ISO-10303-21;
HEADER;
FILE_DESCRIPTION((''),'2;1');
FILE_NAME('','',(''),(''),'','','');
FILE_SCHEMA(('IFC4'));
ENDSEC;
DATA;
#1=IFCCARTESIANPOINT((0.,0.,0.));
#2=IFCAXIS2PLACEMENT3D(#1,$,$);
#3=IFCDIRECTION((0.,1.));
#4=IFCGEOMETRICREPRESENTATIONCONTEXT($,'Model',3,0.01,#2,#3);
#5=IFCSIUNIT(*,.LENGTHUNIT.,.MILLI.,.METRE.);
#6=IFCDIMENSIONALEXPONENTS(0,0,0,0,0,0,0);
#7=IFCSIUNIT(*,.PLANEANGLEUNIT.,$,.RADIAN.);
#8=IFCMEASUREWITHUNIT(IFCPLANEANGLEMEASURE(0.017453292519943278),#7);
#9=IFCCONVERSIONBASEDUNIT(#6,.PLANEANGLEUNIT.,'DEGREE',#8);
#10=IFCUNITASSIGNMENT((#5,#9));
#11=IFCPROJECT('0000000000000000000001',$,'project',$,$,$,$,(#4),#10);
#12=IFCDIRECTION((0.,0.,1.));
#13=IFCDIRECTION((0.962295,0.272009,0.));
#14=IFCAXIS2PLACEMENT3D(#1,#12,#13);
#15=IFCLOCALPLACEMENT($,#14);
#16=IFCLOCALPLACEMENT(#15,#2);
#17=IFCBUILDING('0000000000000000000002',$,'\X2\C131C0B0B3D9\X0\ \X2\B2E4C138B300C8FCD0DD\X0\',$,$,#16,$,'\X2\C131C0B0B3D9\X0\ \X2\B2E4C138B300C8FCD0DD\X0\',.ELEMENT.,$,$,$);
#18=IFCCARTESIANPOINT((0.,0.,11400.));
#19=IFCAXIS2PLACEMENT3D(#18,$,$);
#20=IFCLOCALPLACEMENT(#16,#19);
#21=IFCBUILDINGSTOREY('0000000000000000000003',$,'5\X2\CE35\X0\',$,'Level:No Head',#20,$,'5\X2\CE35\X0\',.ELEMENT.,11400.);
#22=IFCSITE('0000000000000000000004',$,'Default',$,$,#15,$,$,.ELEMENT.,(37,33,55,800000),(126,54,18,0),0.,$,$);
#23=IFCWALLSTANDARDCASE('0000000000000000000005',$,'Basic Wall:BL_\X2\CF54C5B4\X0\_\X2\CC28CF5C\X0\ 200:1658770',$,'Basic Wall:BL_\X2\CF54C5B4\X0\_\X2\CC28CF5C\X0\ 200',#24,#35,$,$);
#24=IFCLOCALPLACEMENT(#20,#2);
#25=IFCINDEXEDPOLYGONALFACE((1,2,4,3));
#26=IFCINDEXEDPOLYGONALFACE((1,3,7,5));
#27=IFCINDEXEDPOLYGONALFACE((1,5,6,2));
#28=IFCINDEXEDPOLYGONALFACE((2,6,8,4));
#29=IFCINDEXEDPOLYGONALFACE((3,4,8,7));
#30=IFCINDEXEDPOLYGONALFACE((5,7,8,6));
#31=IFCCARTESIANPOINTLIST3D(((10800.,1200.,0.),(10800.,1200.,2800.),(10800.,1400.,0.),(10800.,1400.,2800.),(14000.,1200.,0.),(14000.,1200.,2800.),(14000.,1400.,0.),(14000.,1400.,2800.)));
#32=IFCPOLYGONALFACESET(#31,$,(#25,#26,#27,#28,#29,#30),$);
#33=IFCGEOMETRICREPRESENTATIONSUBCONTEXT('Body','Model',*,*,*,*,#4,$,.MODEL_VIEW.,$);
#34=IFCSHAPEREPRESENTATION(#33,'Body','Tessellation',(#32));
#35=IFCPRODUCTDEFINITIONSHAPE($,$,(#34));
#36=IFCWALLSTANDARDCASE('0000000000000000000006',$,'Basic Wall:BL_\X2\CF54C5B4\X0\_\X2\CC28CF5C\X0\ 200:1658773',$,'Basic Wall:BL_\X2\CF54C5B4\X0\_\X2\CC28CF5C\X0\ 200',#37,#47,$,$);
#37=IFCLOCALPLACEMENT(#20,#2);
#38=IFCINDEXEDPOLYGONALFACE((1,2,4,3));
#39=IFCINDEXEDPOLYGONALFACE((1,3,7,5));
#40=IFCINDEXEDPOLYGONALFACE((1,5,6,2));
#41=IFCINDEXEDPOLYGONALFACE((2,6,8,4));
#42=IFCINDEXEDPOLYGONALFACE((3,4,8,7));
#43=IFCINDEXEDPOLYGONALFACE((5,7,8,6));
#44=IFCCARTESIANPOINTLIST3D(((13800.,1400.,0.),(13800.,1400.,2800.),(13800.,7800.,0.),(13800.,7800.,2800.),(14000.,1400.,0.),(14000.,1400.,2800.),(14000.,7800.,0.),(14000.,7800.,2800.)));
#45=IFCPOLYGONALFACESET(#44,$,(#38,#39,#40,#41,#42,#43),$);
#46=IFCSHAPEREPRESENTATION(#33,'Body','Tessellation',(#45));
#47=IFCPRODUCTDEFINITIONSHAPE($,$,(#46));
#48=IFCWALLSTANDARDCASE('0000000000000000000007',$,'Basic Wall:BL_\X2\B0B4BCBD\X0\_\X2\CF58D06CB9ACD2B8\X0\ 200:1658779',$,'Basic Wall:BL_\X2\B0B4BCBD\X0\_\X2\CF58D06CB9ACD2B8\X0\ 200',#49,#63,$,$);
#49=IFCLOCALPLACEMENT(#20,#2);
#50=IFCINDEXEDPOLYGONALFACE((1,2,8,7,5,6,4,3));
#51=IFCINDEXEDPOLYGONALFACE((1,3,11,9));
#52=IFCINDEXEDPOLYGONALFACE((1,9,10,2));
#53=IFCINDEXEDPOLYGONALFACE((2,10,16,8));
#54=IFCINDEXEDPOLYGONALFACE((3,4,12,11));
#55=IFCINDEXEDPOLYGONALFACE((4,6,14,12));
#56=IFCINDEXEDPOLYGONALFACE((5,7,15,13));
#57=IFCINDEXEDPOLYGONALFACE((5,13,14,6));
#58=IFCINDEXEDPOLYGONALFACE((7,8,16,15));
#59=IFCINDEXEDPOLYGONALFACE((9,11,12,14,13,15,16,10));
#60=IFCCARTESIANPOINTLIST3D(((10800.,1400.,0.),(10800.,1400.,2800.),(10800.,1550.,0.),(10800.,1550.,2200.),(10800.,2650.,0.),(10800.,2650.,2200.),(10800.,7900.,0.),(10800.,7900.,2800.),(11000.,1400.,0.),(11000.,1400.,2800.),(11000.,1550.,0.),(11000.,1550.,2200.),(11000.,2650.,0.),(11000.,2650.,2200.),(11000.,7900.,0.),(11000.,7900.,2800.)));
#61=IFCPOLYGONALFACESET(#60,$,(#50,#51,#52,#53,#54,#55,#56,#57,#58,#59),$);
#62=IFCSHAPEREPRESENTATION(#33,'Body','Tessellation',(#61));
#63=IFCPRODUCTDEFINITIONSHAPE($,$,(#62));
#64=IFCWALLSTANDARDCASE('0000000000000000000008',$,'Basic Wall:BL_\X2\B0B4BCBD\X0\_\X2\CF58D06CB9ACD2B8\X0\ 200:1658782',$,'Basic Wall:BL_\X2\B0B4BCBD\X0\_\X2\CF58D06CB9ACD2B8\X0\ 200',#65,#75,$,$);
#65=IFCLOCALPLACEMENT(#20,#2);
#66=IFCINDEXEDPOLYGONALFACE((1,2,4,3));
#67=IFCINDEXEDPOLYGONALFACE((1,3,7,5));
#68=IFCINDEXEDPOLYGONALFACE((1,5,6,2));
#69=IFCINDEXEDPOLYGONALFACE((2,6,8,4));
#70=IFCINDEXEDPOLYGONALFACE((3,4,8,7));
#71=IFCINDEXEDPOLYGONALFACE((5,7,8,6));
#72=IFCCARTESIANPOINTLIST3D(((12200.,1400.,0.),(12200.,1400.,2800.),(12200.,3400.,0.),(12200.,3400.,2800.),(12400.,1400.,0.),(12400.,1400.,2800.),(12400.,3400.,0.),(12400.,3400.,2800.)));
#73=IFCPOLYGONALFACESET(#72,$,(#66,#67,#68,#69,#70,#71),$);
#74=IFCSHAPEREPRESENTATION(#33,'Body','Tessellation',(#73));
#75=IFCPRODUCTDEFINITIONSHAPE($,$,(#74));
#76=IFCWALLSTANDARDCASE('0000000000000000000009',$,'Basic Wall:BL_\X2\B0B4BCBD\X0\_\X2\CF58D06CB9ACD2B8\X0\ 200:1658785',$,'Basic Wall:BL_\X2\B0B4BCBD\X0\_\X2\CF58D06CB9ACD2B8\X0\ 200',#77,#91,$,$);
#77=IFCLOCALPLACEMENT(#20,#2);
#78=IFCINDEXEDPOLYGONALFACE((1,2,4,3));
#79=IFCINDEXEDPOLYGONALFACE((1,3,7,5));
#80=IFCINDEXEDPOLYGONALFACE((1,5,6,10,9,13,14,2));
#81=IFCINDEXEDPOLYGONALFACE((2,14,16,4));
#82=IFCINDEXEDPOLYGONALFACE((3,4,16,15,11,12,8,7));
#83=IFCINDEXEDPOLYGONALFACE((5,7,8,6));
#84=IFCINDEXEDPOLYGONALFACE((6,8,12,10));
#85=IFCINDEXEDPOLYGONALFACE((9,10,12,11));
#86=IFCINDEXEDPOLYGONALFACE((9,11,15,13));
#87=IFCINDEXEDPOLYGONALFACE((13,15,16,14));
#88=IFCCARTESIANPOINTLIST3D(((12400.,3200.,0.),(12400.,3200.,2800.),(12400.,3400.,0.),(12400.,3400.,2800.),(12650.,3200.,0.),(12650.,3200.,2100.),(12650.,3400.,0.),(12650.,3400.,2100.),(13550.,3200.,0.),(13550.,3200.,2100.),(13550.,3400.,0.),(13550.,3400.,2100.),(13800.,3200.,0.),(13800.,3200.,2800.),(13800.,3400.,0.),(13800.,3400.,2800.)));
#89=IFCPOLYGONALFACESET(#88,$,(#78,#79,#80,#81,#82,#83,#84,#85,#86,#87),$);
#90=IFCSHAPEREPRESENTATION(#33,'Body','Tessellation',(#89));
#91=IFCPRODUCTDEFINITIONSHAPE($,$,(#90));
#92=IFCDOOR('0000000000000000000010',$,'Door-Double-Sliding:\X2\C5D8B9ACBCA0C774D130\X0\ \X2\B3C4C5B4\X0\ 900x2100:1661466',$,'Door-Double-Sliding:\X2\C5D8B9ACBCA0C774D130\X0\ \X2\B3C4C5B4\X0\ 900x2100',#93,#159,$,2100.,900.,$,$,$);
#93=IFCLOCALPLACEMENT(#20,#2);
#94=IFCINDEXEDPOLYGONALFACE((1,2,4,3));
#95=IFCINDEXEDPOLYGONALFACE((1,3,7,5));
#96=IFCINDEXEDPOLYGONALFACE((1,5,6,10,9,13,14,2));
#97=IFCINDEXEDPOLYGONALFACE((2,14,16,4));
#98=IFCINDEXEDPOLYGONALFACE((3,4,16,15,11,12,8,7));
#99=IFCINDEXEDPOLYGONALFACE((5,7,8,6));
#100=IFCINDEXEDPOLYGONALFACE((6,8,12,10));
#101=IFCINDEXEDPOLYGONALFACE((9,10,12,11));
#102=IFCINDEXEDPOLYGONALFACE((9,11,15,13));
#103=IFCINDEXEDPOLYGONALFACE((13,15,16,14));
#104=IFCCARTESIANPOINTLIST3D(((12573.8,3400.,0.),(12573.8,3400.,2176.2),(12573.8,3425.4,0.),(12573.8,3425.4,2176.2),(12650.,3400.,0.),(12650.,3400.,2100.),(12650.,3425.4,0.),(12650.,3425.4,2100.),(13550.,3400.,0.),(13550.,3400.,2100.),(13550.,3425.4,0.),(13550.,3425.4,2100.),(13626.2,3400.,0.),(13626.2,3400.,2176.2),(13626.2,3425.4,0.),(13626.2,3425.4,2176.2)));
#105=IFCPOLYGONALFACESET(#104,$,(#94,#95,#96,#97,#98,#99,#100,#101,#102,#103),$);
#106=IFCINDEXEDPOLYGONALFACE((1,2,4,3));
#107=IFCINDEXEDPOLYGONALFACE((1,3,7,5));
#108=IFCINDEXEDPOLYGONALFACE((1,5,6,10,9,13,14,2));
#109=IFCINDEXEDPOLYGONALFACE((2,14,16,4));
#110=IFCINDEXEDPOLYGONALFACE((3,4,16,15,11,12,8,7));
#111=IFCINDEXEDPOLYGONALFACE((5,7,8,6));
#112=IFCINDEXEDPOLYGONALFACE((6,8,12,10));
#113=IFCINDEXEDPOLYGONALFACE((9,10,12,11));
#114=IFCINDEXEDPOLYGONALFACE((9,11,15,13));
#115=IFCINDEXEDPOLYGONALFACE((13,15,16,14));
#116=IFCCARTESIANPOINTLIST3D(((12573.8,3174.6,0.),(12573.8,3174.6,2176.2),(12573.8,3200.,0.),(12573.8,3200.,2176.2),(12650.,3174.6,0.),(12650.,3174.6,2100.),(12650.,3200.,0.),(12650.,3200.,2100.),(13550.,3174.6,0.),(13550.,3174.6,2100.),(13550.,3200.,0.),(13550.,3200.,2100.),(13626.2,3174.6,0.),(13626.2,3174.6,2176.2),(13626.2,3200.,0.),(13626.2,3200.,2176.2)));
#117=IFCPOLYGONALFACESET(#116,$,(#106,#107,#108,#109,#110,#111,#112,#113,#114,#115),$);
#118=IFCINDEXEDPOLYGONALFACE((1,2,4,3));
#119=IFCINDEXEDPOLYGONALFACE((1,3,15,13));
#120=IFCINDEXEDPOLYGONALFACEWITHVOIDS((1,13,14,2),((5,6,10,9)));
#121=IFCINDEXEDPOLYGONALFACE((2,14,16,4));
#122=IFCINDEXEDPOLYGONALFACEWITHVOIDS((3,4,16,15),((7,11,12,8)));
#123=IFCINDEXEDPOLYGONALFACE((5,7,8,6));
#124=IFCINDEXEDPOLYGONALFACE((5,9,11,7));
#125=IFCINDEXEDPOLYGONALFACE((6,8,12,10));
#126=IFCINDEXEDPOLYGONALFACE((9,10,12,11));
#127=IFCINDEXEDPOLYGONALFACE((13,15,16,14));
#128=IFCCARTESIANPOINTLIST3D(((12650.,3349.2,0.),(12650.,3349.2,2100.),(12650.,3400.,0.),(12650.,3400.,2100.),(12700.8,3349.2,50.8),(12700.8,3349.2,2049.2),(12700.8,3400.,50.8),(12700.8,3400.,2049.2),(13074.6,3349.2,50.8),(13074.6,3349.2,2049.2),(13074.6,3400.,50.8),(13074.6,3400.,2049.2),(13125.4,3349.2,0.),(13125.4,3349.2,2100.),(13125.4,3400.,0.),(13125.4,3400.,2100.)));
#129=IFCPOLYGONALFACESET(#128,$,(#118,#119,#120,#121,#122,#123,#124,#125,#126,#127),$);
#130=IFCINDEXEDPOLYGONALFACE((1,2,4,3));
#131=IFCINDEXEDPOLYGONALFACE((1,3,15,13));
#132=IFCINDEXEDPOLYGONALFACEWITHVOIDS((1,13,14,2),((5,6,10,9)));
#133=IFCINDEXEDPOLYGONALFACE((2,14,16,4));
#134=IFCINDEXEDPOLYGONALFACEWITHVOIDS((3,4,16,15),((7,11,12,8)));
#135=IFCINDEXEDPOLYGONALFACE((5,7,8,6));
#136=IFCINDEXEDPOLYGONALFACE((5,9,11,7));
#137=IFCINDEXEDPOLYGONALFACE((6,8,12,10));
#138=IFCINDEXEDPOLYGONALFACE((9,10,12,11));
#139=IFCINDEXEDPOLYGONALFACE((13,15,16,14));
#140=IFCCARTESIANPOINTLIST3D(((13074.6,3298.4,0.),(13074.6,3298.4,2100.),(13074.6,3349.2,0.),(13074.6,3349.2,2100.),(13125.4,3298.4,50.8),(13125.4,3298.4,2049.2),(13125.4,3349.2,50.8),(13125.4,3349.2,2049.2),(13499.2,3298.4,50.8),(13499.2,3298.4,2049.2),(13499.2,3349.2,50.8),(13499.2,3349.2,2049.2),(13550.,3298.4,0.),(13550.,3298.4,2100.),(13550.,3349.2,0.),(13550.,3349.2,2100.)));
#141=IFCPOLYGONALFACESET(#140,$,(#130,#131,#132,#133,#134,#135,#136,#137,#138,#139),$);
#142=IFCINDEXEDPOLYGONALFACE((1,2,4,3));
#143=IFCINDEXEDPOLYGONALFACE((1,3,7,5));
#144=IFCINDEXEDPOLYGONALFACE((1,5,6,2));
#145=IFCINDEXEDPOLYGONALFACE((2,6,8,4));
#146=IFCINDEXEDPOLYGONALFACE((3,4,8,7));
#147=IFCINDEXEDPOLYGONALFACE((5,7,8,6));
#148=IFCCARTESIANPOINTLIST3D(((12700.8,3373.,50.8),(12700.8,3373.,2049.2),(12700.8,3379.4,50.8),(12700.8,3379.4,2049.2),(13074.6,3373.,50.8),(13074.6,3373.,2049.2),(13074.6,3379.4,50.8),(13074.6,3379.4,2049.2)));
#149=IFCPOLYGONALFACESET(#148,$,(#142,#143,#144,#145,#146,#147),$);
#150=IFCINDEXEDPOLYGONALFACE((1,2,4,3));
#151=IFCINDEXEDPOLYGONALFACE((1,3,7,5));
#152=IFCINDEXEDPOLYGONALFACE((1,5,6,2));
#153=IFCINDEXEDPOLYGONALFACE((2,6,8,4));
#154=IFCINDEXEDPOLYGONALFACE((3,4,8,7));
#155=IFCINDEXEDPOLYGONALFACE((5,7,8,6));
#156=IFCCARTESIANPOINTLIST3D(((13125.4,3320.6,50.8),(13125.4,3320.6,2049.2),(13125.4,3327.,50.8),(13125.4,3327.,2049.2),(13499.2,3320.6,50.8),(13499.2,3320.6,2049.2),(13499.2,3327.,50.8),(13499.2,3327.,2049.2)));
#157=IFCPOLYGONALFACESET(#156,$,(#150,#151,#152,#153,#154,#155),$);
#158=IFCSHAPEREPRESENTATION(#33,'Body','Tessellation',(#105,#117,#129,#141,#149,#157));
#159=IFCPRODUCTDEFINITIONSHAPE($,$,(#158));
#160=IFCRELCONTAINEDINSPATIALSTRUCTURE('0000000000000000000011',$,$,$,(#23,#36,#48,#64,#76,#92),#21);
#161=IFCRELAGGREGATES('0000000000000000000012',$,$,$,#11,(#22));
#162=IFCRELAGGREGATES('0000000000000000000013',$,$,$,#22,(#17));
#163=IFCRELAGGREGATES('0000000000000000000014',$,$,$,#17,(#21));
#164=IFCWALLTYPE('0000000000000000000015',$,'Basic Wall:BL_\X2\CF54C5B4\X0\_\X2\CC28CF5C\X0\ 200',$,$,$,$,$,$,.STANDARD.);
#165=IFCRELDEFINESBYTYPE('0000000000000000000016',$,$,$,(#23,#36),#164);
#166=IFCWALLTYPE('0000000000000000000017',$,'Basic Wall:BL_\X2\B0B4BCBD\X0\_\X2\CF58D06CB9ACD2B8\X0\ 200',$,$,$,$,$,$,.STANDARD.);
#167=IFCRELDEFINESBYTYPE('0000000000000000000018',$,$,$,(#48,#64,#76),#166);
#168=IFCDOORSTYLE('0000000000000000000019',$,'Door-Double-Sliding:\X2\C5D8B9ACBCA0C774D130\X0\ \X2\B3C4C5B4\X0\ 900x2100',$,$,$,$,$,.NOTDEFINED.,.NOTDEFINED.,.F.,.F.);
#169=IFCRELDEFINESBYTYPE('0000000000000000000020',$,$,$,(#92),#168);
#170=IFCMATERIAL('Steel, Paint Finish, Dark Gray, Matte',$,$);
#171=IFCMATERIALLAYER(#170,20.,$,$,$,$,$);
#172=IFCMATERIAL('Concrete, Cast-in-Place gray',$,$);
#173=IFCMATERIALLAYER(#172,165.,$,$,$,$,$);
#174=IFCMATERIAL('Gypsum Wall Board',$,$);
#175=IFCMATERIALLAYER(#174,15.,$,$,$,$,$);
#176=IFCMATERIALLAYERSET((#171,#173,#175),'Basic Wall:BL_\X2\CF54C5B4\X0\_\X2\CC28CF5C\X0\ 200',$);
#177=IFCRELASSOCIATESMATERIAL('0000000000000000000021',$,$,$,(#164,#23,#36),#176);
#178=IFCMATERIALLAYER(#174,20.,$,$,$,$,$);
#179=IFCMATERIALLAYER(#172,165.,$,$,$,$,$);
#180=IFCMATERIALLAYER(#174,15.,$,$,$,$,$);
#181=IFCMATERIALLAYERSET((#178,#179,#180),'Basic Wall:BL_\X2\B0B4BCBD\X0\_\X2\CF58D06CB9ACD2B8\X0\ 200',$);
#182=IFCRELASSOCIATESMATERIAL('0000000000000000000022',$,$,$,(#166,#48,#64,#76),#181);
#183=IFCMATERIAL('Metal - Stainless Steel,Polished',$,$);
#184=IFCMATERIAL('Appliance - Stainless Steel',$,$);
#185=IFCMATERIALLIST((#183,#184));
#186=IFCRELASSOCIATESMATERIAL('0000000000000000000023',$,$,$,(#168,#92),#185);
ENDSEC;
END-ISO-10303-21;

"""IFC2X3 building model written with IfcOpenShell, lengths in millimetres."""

from ifc_helpers import new_model, entity, si_unit, converted_unit, direction, frame, frame_2d, origin, place, context, subcontext, project, spatial, polyline, rectangle, outline, extrude, source, transform, mapped, material, material_list, layer, layer_set, layer_usage, type_object, type_shapes, element, fill, save


model = new_model("IFC2X3")

# Units and contexts
model_context = context("Model", 3, precision=0.01, world=origin(), true_north=direction((0.0, 1.0)))
body_context = subcontext(model_context, "Body", "Model", "MODEL_VIEW")
ifc_project = project(units=[si_unit("LENGTHUNIT", "METRE", prefix="MILLI"), converted_unit("PLANEANGLEUNIT", "DEGREE", entity("IfcPlaneAngleMeasure", 0.017453292519943278), si_unit("PLANEANGLEUNIT", "RADIAN"), dimensions=[0, 0, 0, 0, 0, 0, 0])], contexts=[model_context])

# Site, building, storey
site_placement = place(None, frame((0.0, 0.0, 0.0), z_axis=(0.0, 0.0, 1.0), x_axis=(0.962295, 0.272009, 0.0)))
site = spatial("IfcSite", under=ifc_project, at=site_placement, Name="Default", CompositionType="ELEMENT", RefLatitude=(37, 33, 55, 800000), RefLongitude=(126, 54, 18, 0), RefElevation=0.0)
building_placement = place(site_placement, origin())
building = spatial("IfcBuilding", under=site, at=building_placement, Name="성산동 다세대주택", LongName="성산동 다세대주택", CompositionType="ELEMENT")
storey_placement = place(building_placement, frame((0.0, 0.0, 11400.0)))
storey = spatial("IfcBuildingStorey", under=building, at=storey_placement, Name="5층", ObjectType="Level:No Head", LongName="5층", CompositionType="ELEMENT", Elevation=11400.0)

# Walls
ifc_material_1 = material(Name="Steel, Paint Finish, Dark Gray, Matte")
ifc_layer_1 = layer(ifc_material_1, 20.0)
ifc_material_2 = material(Name="Concrete, Cast-in-Place gray")
ifc_layer_2 = layer(ifc_material_2, 165.0)
ifc_material_3 = material(Name="Gypsum Wall Board")
ifc_layer_3 = layer(ifc_material_3, 15.0)
ifc_layer_set_1 = layer_set([ifc_layer_1, ifc_layer_2, ifc_layer_3], Name="Basic Wall:BL_코어_차콜 200")
ifc_layer_usage_1 = layer_usage(ifc_layer_set_1, "AXIS2", "POSITIVE", -100.0)
wall_type_1 = type_object("IfcWallType", Name="Basic Wall:BL_코어_차콜 200", PredefinedType="STANDARD", material=ifc_layer_set_1)
wall_1_placement = place(storey_placement, frame((10800.0, 1300.0, 0.0)))
element("IfcWallStandardCase", 1, at=wall_1_placement, inside=storey, type_object=wall_type_1, material=ifc_layer_usage_1, Name="Basic Wall:BL_코어_차콜 200:1658770", ObjectType="Basic Wall:BL_코어_차콜 200", context=body_context, shape_type="SweptSolid", body=[
    extrude(rectangle(XDim=3200.0, YDim=200.0, at=frame_2d((1600.0, 0.0), x_axis=(-1.0, 0.0))), origin(), (0.0, 0.0, 1.0), 2800.0),
])
ifc_layer_usage_2 = layer_usage(ifc_layer_set_1, "AXIS2", "POSITIVE", -100.0)
wall_2_placement = place(storey_placement, frame((13900.0, 1400.0, 0.0), z_axis=(0.0, 0.0, 1.0), x_axis=(0.0, 1.0, 0.0)))
element("IfcWallStandardCase", 2, at=wall_2_placement, inside=storey, type_object=wall_type_1, material=ifc_layer_usage_2, Name="Basic Wall:BL_코어_차콜 200:1658773", ObjectType="Basic Wall:BL_코어_차콜 200", context=body_context, shape_type="SweptSolid", body=[
    extrude(rectangle(XDim=6400.0, YDim=200.0, at=frame_2d((3200.0, 0.0), x_axis=(-1.0, 0.0))), origin(), (0.0, 0.0, 1.0), 2800.0),
])

# Wall, openings
ifc_layer_4 = layer(ifc_material_3, 20.0)
ifc_layer_5 = layer(ifc_material_2, 165.0)
ifc_layer_6 = layer(ifc_material_3, 15.0)
ifc_layer_set_2 = layer_set([ifc_layer_4, ifc_layer_5, ifc_layer_6], Name="Basic Wall:BL_내벽_콘크리트 200")
ifc_layer_usage_3 = layer_usage(ifc_layer_set_2, "AXIS2", "NEGATIVE", 100.0)
wall_type_2 = type_object("IfcWallType", Name="Basic Wall:BL_내벽_콘크리트 200", PredefinedType="STANDARD", material=ifc_layer_set_2)
wall_3_placement = place(storey_placement, frame((10900.0, 7900.0, 0.0), z_axis=(0.0, 0.0, 1.0), x_axis=(0.0, -1.0, 0.0)))
wall_3 = element("IfcWallStandardCase", 3, at=wall_3_placement, inside=storey, type_object=wall_type_2, material=ifc_layer_usage_3, Name="Basic Wall:BL_내벽_콘크리트 200:1658779", ObjectType="Basic Wall:BL_내벽_콘크리트 200", context=body_context, shape_type="SweptSolid", body=[
    extrude(rectangle(XDim=6500.0, YDim=200.0, at=frame_2d((3250.0, 0.0), x_axis=(1.0, 0.0))), origin(), (0.0, 0.0, 1.0), 2800.0),
])
opening_1_placement = place(wall_3_placement, origin())
element("IfcOpeningElement", 4, at=opening_1_placement, cuts=wall_3, ObjectType="Opening", context=body_context, shape_type="SweptSolid", body=[
    extrude(rectangle(XDim=2200.0, YDim=1000.0, at=frame_2d((0.0, 0.0), x_axis=(0.0, 1.0))), frame((5800.0, -1624.0, 3900.0), z_axis=(0.0, 1.0, 0.0), x_axis=(-1.0, 0.0, 0.0)), (0.0, 0.0, 1.0), 3048.0),
])
opening_2_placement = place(wall_3_placement, frame((5250.0, -100.0, 0.0)))
element("IfcOpeningElement", 5, at=opening_2_placement, cuts=wall_3, ObjectType="Opening", context=body_context, shape_type="SweptSolid", body=[
    extrude(rectangle(XDim=2200.0, YDim=1100.0, at=frame_2d((1100.0, 550.0), x_axis=(1.0, 0.0))), frame((0.0, 0.0, 0.0), z_axis=(0.0, 1.0, 0.0), x_axis=(0.0, 0.0, 1.0)), (0.0, 0.0, 1.0), 200.0),
])

# Wall
ifc_layer_usage_4 = layer_usage(ifc_layer_set_2, "AXIS2", "NEGATIVE", 100.0)
wall_4_placement = place(storey_placement, frame((12300.0, 1400.0, 0.0), z_axis=(0.0, 0.0, 1.0), x_axis=(0.0, 1.0, 0.0)))
element("IfcWallStandardCase", 6, at=wall_4_placement, inside=storey, type_object=wall_type_2, material=ifc_layer_usage_4, Name="Basic Wall:BL_내벽_콘크리트 200:1658782", ObjectType="Basic Wall:BL_내벽_콘크리트 200", context=body_context, shape_type="SweptSolid", body=[
    extrude(rectangle(XDim=2000.0, YDim=200.0, at=frame_2d((1000.0, 0.0), x_axis=(-1.0, 0.0))), origin(), (0.0, 0.0, 1.0), 2800.0),
])

# Wall, opening, door
ifc_layer_usage_5 = layer_usage(ifc_layer_set_2, "AXIS2", "NEGATIVE", 100.0)
wall_5_placement = place(storey_placement, frame((12400.0, 3300.0, 0.0)))
wall_5 = element("IfcWallStandardCase", 7, at=wall_5_placement, inside=storey, type_object=wall_type_2, material=ifc_layer_usage_5, Name="Basic Wall:BL_내벽_콘크리트 200:1658785", ObjectType="Basic Wall:BL_내벽_콘크리트 200", context=body_context, shape_type="SweptSolid", body=[
    extrude(rectangle(XDim=1400.0, YDim=200.0, at=frame_2d((700.0, 0.0), x_axis=(1.0, 0.0))), origin(), (0.0, 0.0, 1.0), 2800.0),
])
opening_3_placement = place(wall_5_placement, frame((250.0, -100.0, 0.0)))
opening_3 = element("IfcOpeningElement", 8, at=opening_3_placement, cuts=wall_5, ObjectType="Opening", context=body_context, shape_type="SweptSolid", body=[
    extrude(rectangle(XDim=2100.0, YDim=900.0, at=frame_2d((1050.0, 450.0), x_axis=(-1.0, 0.0))), frame((0.0, 0.0, 0.0), z_axis=(0.0, 1.0, 0.0), x_axis=(0.0, 0.0, 1.0)), (0.0, 0.0, 1.0), 200.0),
])
ifc_material_4 = material(Name="Metal - Stainless Steel,Polished")
ifc_material_5 = material(Name="Appliance - Stainless Steel")
ifc_material_list_1 = material_list([ifc_material_4, ifc_material_5])
door_style = type_object("IfcDoorStyle", Name="Door-Double-Sliding:엘리베이터 도어 900x2100", ConstructionType="NOTDEFINED", OperationType="NOTDEFINED", ParameterTakesPrecedence=False, Sizeable=False, material=ifc_material_list_1)
shared_shape_1 = source(origin(), body_context, "Body", "SweptSolid", [
    extrude(outline(polyline([(-526.2, -1069.1), (-450.0, -1069.1), (-450.0, 1030.9), (450.0, 1031.0), (450.0, -1069.0), (526.2, -1069.0), (526.2, 1107.1), (-526.2, 1107.1), (-526.2, -1069.1)])), frame((450.0, 200.0, 1069.0), z_axis=(0.0, 1.0, 0.0), x_axis=(-1.0, 0.0, 0.0)), (0.0, 0.0, 1.0), 25.4),
    extrude(outline(polyline([(-1069.0, -526.2), (1107.1, -526.2), (1107.1, 526.2), (-1069.0, 526.2), (-1069.0, 450.0), (1030.9, 450.0), (1030.9, -450.0), (-1069.0, -450.0), (-1069.0, -526.2)])), frame((450.0, -25.4, 1069.0), z_axis=(0.0, 1.0, 0.0), x_axis=(0.0, 0.0, 1.0)), (0.0, 0.0, 1.0), 25.4),
    extrude(outline(polyline([(-1050.0, -237.7), (1050.0, -237.7), (1050.0, 237.7), (-1050.0, 237.7), (-1050.0, -237.7)]), holes=[polyline([(-999.2, -186.9), (-999.2, 186.9), (999.2, 186.9), (999.2, -186.9), (-999.2, -186.9)])]), frame((237.7, 149.2, 1050.0), z_axis=(0.0, 1.0, 0.0), x_axis=(0.0, 0.0, -1.0)), (0.0, 0.0, 1.0), 50.8),
    extrude(outline(polyline([(-237.7, -1050.0), (237.7, -1050.0), (237.7, 1050.0), (-237.7, 1050.0), (-237.7, -1050.0)]), holes=[polyline([(-186.9, -999.2), (-186.9, 999.2), (186.9, 999.2), (186.9, -999.2), (-186.9, -999.2)])]), frame((662.3, 98.4, 1050.0), z_axis=(0.0, 1.0, 0.0), x_axis=(1.0, 0.0, 0.0)), (0.0, 0.0, 1.0), 50.8),
    extrude(rectangle(XDim=6.4, YDim=373.8, at=frame_2d((0.0, 0.0), x_axis=(1.0, 0.0))), frame((237.7, 176.2, 50.8), z_axis=(0.0, 0.0, 1.0), x_axis=(0.0, 1.0, 0.0)), (0.0, 0.0, 1.0), 1998.4),
    extrude(rectangle(XDim=6.3, YDim=373.8, at=frame_2d((0.0, 0.0), x_axis=(1.0, 0.0))), frame((662.3, 123.8, 50.8), z_axis=(0.0, 0.0, 1.0), x_axis=(0.0, -1.0, 0.0)), (0.0, 0.0, 1.0), 1998.4),
])
type_shapes(door_style, [shared_shape_1])
door_placement = place(opening_3_placement, origin())
door = element("IfcDoor", 9, at=door_placement, inside=storey, type_object=door_style, material=ifc_material_list_1, Name="Door-Double-Sliding:엘리베이터 도어 900x2100:1661466", ObjectType="Door-Double-Sliding:엘리베이터 도어 900x2100", OverallHeight=2100.0, OverallWidth=900.0, context=body_context, shape_type="MappedRepresentation", body=[
    mapped(shared_shape_1, transform((0.0, 0.0, 0.0), scale=1.0)),
])
fill(opening_3, door)

save(model, "model.ifc")
